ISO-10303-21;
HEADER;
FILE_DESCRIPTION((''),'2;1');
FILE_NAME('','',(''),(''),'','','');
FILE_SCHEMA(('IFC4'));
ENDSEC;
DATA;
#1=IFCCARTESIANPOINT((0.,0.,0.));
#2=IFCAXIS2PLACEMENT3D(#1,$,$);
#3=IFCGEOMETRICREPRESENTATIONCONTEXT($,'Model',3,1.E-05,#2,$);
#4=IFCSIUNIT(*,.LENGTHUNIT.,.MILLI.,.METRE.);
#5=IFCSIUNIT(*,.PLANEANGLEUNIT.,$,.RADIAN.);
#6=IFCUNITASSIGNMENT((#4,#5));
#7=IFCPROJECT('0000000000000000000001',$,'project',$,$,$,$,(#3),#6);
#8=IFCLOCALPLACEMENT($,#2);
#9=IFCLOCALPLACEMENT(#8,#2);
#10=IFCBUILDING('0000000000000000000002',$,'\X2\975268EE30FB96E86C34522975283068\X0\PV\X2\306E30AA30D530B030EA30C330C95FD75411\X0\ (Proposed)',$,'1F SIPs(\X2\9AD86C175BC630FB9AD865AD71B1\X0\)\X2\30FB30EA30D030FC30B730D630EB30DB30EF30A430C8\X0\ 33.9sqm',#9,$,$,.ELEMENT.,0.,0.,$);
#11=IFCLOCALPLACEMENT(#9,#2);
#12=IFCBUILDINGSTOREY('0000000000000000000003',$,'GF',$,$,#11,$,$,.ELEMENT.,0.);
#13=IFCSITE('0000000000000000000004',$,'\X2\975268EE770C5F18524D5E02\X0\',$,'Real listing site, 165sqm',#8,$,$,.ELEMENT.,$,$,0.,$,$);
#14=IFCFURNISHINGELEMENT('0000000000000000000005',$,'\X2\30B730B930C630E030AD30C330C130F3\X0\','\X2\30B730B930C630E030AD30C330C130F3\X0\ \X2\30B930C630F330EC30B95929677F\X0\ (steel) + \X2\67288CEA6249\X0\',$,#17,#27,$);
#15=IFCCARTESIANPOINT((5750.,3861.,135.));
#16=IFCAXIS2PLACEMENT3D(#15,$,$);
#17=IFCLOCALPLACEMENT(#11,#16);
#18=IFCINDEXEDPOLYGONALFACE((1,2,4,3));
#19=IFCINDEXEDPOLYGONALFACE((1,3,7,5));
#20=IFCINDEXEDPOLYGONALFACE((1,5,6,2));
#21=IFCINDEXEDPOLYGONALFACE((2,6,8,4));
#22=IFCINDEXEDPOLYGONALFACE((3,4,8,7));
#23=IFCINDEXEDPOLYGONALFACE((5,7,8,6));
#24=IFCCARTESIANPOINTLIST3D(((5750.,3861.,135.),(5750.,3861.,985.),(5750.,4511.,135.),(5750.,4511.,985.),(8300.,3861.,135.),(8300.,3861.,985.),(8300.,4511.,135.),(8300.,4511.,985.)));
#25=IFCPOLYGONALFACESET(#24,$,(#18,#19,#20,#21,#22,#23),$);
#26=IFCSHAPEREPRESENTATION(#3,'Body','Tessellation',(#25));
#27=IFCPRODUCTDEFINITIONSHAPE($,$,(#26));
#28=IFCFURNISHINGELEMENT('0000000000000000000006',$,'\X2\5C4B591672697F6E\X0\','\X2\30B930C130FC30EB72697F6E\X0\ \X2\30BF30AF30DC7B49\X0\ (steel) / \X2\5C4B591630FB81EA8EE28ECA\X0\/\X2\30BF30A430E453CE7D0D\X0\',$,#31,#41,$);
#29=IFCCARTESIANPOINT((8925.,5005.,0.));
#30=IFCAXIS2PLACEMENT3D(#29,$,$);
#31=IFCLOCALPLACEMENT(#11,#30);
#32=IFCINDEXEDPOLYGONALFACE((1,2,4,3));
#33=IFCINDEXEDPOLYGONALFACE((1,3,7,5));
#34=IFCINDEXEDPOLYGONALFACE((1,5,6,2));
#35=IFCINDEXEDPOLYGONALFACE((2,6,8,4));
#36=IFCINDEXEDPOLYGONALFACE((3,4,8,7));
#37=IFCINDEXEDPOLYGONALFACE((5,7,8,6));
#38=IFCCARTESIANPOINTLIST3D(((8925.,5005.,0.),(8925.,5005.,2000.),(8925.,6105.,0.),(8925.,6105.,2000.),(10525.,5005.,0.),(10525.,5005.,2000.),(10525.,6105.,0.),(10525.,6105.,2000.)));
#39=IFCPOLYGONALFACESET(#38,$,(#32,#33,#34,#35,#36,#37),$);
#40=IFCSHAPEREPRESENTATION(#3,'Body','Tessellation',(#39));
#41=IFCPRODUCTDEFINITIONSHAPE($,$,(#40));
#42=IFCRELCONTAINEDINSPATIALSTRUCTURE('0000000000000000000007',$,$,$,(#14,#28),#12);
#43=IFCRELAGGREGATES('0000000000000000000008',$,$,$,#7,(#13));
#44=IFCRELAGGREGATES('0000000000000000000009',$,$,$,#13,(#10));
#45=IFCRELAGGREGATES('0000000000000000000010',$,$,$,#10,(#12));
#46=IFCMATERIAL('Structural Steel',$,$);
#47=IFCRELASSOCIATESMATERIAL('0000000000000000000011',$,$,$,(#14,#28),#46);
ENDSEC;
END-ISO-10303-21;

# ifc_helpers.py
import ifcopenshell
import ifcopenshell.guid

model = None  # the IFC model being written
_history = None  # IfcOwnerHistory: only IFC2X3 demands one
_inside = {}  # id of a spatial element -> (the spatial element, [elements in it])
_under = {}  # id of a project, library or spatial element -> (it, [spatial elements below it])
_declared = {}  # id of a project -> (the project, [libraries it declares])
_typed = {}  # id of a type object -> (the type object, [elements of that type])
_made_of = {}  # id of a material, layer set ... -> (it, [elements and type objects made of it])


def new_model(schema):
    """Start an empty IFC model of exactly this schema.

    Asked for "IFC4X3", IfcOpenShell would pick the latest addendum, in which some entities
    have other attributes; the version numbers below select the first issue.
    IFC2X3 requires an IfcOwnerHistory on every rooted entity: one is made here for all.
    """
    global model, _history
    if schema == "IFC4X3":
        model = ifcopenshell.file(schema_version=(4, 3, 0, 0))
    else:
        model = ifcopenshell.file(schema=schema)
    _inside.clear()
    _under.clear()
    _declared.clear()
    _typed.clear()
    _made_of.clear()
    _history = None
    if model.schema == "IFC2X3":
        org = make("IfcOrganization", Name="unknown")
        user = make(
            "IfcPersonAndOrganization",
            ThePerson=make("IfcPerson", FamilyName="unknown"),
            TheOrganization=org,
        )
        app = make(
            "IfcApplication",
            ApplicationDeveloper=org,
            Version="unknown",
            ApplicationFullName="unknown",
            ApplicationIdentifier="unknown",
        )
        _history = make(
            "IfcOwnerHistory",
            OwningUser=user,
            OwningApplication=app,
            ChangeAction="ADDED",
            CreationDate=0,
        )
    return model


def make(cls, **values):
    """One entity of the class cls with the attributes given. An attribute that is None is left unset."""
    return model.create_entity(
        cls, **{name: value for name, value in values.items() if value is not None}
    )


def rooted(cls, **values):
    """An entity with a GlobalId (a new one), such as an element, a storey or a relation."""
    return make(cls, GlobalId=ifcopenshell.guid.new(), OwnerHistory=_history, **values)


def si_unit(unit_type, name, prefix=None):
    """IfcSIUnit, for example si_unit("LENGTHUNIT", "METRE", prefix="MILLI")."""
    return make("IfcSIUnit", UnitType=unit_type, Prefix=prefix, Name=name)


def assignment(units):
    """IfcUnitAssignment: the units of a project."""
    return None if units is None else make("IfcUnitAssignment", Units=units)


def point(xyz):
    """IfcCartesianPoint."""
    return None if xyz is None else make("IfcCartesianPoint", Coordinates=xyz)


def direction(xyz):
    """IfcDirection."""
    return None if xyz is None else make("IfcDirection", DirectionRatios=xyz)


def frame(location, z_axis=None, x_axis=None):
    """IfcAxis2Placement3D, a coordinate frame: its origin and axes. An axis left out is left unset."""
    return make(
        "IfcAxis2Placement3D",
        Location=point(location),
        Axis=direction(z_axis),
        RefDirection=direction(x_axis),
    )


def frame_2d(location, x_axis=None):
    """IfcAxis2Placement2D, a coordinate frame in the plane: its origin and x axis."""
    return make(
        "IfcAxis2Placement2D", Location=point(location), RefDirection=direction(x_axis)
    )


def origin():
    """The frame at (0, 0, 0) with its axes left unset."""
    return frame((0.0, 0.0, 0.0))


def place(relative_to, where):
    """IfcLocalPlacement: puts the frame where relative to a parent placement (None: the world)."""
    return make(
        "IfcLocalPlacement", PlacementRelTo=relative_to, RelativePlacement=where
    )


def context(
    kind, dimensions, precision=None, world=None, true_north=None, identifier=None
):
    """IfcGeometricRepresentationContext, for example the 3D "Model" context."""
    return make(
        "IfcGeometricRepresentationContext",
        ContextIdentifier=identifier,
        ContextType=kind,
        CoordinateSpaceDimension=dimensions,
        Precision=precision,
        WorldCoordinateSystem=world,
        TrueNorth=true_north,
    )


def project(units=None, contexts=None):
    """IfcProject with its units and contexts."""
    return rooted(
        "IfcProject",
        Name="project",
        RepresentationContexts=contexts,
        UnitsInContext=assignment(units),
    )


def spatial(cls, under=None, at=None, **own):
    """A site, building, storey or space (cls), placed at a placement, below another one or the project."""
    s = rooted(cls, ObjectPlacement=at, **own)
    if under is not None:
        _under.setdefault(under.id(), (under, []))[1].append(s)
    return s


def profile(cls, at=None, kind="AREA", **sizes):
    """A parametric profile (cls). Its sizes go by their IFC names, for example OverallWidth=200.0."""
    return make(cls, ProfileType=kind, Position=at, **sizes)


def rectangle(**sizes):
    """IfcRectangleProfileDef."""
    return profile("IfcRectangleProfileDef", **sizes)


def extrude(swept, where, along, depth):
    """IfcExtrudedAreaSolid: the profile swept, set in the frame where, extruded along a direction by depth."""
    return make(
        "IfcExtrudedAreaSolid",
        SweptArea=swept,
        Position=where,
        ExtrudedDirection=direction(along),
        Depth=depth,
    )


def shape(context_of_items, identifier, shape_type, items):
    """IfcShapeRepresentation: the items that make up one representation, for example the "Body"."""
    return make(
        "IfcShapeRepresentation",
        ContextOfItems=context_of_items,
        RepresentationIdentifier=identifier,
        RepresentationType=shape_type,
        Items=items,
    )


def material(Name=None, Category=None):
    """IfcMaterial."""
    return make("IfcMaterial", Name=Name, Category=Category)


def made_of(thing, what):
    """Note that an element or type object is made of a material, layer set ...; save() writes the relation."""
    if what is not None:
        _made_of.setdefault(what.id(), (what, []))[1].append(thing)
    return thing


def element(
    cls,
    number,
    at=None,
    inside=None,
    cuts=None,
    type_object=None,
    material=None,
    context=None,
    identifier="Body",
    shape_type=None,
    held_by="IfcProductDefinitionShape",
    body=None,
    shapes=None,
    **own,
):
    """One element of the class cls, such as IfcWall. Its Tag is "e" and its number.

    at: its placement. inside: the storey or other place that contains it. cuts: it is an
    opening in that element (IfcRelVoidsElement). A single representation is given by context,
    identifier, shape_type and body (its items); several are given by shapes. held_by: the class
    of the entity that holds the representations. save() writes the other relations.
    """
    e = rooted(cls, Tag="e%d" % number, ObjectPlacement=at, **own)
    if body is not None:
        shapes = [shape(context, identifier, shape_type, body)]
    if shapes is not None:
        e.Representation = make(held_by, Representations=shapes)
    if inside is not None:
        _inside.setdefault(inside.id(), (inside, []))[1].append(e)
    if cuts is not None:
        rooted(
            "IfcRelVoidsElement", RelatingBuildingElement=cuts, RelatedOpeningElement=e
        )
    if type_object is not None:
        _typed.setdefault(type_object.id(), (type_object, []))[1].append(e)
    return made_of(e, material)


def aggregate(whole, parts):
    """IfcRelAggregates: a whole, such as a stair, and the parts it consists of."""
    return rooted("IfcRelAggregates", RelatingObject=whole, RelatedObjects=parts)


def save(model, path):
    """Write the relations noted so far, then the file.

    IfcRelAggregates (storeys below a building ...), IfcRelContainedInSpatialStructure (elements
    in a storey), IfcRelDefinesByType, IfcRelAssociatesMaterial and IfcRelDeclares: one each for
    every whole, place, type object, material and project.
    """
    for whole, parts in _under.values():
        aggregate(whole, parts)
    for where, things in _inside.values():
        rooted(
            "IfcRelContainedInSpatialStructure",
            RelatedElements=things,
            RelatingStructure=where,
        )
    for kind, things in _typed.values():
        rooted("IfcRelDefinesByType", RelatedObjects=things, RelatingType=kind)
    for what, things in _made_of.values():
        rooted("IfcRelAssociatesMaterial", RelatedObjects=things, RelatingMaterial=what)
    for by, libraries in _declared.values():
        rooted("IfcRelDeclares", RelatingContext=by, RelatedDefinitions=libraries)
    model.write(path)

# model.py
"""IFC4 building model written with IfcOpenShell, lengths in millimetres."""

from ifc_helpers import new_model, si_unit, frame, frame_2d, origin, place, context, project, spatial, rectangle, extrude, material, element, save


model = new_model("IFC4")

# Units and contexts
model_context = context("Model", 3, precision=1e-05, world=origin())
ifc_project = project(units=[si_unit("LENGTHUNIT", "METRE", prefix="MILLI"), si_unit("PLANEANGLEUNIT", "RADIAN")], contexts=[model_context])

# Site, building, storey
site_placement = place(None, origin())
site = spatial("IfcSite", under=ifc_project, at=site_placement, Name="青森県弘前市", ObjectType="Real listing site, 165sqm", CompositionType="ELEMENT", RefElevation=0.0)
building_placement = place(site_placement, origin())
building = spatial("IfcBuilding", under=site, at=building_placement, Name="青森・雨水利用とPVのオフグリッド志向 (Proposed)", ObjectType="1F SIPs(高気密・高断熱)・リバーシブルホワイト 33.9sqm", CompositionType="ELEMENT", ElevationOfRefHeight=0.0, ElevationOfTerrain=0.0)
storey_placement = place(building_placement, origin())
storey = spatial("IfcBuildingStorey", under=building, at=storey_placement, Name="GF", CompositionType="ELEMENT", Elevation=0.0)

# Shared definitions
ifc_material_1 = material(Name="Structural Steel")

# Furnishing elements
furnishing_1_placement = place(storey_placement, frame((5750.0, 3861.0, 135.0)))
element("IfcFurnishingElement", 1, at=furnishing_1_placement, inside=storey, material=ifc_material_1, Name="システムキッチン", Description="システムキッチン ステンレス天板 (steel) + 木質扉", context=model_context, shape_type="SweptSolid", body=[
    extrude(rectangle(XDim=2550.0, YDim=650.0, at=frame_2d((1275.0, 325.0))), frame((5750.0, 3861.0, 135.0)), (0.0, 0.0, 1.0), 850.0),
])
furnishing_2_placement = place(storey_placement, frame((8925.0, 5005.0, 0.0)))
element("IfcFurnishingElement", 2, at=furnishing_2_placement, inside=storey, material=ifc_material_1, Name="屋外物置", Description="スチール物置 タクボ等 (steel) / 屋外・自転車/タイヤ収納", context=model_context, shape_type="SweptSolid", body=[
    extrude(rectangle(XDim=1600.0, YDim=1100.0, at=frame_2d((800.0, 550.0))), frame((8925.0, 5005.0, 0.0)), (0.0, 0.0, 1.0), 2000.0),
])

save(model, "model.ifc")
